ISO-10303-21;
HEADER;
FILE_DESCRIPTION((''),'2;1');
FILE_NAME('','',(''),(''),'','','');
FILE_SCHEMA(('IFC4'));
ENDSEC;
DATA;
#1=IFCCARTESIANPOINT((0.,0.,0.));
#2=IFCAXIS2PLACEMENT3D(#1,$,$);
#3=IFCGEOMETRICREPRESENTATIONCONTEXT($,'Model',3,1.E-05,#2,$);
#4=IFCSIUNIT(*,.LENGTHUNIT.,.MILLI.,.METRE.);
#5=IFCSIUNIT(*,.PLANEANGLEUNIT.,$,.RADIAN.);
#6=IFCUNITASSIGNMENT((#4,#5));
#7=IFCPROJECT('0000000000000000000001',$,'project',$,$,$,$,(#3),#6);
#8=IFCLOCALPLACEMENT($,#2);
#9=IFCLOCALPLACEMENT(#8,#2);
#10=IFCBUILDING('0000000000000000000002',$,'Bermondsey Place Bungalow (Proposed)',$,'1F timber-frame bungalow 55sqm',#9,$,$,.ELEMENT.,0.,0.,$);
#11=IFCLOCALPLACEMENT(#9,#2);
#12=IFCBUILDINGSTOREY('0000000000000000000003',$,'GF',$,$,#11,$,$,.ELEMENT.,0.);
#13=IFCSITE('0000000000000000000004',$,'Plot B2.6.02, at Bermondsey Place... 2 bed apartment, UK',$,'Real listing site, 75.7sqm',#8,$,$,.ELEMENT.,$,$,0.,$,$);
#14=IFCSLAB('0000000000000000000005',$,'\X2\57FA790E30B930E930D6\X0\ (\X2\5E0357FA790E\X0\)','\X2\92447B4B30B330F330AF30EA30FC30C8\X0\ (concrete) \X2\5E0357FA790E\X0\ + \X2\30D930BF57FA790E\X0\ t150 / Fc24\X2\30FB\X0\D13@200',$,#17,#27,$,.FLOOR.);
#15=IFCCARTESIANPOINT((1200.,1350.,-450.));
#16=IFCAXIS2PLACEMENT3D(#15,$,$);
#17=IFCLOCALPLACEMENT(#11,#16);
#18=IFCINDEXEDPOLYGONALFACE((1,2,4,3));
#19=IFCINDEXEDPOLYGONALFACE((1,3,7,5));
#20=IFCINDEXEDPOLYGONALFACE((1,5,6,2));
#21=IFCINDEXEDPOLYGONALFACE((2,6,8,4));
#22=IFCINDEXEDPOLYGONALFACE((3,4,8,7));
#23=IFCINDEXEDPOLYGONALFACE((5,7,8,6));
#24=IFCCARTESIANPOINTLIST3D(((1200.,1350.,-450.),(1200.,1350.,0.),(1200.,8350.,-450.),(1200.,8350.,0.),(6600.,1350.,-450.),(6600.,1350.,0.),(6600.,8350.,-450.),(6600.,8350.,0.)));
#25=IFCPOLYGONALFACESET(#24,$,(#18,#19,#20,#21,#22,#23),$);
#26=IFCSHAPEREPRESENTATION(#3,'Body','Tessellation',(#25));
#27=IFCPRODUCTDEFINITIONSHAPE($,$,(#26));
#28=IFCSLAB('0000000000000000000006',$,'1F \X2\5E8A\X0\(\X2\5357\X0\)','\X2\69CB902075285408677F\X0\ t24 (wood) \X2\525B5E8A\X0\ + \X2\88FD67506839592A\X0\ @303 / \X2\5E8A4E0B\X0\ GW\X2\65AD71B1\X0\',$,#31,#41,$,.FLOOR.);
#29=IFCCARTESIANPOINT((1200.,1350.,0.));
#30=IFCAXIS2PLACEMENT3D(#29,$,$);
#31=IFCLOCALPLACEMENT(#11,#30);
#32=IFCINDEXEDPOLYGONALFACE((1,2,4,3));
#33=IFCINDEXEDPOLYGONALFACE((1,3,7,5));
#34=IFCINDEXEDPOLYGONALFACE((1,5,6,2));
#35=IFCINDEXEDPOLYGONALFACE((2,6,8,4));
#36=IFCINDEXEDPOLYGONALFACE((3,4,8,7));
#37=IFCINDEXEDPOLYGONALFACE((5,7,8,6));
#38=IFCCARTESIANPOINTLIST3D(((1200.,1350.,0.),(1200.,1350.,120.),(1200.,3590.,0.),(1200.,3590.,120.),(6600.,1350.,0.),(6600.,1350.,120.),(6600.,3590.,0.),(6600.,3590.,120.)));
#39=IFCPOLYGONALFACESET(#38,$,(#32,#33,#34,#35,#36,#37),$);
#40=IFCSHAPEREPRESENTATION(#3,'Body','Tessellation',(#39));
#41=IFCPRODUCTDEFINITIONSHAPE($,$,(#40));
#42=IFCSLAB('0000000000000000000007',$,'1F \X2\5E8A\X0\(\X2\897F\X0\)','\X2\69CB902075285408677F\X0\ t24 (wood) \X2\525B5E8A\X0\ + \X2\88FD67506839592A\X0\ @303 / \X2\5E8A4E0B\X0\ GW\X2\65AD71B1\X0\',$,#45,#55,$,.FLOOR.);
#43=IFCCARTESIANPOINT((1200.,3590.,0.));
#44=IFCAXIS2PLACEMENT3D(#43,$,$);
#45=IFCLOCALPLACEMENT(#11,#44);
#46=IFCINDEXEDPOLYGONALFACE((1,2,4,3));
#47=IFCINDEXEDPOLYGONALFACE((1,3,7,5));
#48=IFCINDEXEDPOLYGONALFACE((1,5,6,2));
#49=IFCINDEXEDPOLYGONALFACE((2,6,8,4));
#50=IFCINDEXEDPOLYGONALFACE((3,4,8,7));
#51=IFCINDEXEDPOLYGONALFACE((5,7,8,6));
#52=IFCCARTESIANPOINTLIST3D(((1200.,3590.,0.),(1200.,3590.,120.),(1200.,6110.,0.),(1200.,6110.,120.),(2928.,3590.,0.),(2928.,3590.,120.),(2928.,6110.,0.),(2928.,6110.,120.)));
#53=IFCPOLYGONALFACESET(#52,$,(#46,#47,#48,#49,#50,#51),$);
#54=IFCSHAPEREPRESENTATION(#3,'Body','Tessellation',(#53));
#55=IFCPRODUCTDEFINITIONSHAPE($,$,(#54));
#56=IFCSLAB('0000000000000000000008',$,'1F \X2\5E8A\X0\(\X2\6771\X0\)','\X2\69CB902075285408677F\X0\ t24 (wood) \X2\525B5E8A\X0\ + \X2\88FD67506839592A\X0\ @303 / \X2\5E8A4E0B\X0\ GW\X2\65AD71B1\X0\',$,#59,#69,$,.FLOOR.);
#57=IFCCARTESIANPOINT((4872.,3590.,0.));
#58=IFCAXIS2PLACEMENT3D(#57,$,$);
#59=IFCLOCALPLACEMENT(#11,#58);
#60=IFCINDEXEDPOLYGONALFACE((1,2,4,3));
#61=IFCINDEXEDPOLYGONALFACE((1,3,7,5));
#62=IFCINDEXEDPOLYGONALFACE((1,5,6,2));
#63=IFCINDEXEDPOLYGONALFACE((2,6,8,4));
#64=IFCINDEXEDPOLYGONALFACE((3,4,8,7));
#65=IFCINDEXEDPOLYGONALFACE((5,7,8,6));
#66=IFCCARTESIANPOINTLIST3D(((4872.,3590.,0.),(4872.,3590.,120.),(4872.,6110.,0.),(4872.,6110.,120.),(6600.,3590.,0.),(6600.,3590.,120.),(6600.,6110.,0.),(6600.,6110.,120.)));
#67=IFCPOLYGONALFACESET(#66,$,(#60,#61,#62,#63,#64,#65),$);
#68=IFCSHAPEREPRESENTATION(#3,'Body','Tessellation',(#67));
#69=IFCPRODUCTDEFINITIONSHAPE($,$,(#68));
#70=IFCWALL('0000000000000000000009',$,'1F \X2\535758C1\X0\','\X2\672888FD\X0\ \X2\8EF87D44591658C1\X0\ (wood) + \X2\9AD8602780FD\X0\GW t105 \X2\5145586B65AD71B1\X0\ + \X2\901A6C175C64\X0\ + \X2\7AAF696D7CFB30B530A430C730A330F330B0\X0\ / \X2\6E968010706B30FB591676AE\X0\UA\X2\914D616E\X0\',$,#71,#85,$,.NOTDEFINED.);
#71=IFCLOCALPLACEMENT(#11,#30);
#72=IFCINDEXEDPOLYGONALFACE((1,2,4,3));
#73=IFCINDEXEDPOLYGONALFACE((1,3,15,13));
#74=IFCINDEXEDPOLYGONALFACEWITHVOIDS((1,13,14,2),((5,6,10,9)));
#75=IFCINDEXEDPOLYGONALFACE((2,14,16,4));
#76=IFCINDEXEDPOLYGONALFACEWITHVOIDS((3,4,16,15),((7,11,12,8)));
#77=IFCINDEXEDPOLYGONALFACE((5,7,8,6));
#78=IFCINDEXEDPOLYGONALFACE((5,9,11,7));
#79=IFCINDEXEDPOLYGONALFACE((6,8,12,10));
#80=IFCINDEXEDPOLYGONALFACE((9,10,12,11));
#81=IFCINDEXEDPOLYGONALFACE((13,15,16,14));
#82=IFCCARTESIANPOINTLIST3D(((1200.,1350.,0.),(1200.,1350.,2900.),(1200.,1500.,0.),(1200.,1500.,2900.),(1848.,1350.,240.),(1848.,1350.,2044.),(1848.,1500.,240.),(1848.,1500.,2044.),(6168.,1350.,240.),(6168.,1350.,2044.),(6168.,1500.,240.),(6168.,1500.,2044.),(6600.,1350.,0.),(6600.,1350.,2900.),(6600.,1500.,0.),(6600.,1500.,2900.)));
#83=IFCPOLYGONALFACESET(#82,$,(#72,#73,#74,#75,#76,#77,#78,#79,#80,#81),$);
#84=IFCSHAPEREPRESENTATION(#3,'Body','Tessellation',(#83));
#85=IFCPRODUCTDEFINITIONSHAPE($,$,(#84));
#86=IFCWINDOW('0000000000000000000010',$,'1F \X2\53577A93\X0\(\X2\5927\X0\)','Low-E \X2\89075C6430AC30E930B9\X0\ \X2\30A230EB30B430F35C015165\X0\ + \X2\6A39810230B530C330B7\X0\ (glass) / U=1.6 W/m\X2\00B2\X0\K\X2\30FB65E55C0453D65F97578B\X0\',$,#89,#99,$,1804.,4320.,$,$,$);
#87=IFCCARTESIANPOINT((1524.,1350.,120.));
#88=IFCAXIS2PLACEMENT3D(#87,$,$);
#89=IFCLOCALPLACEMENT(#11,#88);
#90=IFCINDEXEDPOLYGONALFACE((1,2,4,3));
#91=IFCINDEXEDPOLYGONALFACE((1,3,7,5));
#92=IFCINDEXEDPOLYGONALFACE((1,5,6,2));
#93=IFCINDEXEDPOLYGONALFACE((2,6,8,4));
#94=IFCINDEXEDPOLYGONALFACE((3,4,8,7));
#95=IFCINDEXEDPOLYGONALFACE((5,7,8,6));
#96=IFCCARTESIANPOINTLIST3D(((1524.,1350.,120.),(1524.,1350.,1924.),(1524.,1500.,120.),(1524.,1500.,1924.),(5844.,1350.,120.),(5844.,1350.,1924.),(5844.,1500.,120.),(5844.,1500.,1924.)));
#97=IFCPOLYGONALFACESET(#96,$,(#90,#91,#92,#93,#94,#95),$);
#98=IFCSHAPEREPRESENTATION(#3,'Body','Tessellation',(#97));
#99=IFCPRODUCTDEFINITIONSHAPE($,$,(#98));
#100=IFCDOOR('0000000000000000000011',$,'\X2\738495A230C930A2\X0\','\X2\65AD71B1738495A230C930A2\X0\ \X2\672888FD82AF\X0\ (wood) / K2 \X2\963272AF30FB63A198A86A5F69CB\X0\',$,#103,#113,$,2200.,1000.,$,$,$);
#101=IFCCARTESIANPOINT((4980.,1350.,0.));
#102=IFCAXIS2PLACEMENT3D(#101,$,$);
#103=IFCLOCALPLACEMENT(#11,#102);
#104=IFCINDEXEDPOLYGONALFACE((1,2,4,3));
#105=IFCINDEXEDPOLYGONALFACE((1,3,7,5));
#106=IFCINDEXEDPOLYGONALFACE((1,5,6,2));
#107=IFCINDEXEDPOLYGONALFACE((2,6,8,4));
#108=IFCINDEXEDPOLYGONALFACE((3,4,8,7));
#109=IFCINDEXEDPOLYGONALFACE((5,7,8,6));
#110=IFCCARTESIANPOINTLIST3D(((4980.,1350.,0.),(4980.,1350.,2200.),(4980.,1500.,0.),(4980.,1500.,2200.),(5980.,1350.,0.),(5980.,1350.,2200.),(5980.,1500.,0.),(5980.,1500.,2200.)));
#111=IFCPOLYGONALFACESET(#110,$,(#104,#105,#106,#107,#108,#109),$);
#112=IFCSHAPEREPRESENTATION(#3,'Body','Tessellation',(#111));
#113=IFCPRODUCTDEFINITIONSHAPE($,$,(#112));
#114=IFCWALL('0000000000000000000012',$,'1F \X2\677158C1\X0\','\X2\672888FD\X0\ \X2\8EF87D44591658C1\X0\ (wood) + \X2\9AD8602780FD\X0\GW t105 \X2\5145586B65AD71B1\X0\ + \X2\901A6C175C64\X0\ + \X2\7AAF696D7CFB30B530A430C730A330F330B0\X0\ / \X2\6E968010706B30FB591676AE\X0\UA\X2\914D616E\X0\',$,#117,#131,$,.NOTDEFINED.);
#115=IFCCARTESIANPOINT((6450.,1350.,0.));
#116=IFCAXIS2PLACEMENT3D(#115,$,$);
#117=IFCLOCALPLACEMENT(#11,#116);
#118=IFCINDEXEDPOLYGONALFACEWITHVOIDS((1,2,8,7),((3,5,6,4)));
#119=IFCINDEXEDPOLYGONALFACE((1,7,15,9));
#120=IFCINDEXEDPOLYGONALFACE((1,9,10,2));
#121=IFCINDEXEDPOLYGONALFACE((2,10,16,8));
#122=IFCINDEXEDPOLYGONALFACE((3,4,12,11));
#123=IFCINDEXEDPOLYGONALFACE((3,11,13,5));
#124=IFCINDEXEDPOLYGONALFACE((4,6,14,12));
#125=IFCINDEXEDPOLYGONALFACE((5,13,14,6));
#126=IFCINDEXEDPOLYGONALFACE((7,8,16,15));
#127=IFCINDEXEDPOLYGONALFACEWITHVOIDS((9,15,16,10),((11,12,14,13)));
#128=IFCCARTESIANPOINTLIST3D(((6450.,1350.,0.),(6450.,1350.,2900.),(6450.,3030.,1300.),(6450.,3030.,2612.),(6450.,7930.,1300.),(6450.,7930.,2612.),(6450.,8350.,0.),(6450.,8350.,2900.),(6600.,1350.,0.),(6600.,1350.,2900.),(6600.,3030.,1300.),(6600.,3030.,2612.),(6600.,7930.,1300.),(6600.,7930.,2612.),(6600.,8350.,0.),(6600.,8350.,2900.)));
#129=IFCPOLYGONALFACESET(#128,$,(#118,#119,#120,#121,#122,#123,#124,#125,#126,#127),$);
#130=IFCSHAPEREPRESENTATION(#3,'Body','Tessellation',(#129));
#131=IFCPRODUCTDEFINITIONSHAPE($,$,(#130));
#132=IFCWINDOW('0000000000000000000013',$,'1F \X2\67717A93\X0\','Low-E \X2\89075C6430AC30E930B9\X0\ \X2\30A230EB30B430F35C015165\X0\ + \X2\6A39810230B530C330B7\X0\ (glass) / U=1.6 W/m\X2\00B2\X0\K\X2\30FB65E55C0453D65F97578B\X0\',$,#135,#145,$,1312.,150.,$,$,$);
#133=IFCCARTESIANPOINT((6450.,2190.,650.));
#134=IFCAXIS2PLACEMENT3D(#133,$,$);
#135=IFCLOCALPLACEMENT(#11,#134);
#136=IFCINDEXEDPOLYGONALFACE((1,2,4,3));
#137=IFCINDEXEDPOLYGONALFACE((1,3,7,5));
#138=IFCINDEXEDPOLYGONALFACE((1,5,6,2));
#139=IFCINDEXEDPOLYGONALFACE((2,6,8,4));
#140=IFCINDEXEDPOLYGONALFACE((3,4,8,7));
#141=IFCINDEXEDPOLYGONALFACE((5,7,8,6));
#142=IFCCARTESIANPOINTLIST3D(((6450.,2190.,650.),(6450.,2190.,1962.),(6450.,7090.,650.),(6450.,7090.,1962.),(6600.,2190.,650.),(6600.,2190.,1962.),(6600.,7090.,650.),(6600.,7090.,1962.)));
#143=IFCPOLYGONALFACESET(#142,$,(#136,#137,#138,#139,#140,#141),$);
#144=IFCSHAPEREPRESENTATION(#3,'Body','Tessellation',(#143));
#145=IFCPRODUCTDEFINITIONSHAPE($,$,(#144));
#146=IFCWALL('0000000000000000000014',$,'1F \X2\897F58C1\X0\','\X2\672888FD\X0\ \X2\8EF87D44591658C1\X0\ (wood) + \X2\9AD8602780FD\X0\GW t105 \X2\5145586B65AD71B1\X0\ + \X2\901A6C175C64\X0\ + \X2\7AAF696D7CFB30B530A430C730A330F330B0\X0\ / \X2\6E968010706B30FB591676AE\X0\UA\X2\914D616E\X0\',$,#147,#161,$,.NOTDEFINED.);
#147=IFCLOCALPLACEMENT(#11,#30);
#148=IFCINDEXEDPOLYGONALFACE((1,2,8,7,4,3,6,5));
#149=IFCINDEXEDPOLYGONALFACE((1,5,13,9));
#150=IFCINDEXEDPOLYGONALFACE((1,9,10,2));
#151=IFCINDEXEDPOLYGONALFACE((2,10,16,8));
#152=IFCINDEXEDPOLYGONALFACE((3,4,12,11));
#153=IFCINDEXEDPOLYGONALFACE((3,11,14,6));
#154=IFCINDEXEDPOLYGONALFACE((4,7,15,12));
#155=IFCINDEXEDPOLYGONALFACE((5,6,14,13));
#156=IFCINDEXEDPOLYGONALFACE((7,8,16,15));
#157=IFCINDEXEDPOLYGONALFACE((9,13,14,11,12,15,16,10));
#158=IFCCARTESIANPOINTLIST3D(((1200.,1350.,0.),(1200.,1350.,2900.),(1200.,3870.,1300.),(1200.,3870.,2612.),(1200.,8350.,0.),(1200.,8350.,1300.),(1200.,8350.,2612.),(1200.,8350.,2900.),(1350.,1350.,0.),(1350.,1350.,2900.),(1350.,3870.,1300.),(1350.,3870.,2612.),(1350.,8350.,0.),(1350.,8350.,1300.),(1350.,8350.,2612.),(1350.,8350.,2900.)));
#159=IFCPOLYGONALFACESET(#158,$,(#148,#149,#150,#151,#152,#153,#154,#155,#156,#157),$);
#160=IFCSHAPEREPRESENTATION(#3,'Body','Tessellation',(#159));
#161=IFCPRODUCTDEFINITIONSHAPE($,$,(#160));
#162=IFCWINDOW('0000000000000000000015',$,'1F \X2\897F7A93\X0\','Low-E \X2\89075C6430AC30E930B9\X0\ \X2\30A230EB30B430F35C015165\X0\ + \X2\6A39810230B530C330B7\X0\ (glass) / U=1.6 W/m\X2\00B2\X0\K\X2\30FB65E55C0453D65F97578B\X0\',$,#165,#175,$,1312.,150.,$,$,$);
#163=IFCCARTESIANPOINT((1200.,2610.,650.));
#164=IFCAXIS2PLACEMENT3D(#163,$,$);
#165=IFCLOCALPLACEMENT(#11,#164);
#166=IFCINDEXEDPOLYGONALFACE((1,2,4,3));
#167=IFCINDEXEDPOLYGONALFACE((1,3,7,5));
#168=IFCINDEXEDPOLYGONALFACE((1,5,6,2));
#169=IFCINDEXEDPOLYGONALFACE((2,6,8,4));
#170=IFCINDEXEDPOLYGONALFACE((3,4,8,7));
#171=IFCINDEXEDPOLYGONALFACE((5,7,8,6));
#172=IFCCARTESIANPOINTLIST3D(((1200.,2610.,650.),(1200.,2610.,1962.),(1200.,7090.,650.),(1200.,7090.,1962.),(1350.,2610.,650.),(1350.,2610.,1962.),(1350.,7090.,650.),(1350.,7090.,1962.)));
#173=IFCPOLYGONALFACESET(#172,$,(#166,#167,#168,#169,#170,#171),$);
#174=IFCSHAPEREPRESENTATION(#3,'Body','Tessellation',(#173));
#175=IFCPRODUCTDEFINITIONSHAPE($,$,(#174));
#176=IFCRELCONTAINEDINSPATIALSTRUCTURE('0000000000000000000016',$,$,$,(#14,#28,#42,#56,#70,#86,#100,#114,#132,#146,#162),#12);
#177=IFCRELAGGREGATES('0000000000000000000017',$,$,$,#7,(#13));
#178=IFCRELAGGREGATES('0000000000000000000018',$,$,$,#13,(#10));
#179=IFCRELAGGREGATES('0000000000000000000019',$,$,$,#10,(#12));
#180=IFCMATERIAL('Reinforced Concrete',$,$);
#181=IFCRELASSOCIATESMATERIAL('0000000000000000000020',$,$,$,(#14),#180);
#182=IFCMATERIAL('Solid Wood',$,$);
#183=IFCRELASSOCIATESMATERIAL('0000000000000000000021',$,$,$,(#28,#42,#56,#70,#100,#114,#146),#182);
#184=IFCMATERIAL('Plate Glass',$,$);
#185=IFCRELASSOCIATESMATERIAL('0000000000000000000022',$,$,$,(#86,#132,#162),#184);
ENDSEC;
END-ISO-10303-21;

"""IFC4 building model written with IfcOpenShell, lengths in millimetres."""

from ifc_helpers import new_model, si_unit, frame, frame_2d, origin, place, context, project, spatial, rectangle, extrude, material, element, fill, save


model = new_model("IFC4")

# Units and contexts
model_context = context("Model", 3, precision=1e-05, world=origin())
ifc_project = project(units=[si_unit("LENGTHUNIT", "METRE", prefix="MILLI"), si_unit("PLANEANGLEUNIT", "RADIAN")], contexts=[model_context])

# Site, building, storey
site_placement = place(None, origin())
site = spatial("IfcSite", under=ifc_project, at=site_placement, Name="Plot B2.6.02, at Bermondsey Place... 2 bed apartment, UK", ObjectType="Real listing site, 75.7sqm", CompositionType="ELEMENT", RefElevation=0.0)
building_placement = place(site_placement, origin())
building = spatial("IfcBuilding", under=site, at=building_placement, Name="Bermondsey Place Bungalow (Proposed)", ObjectType="1F timber-frame bungalow 55sqm", CompositionType="ELEMENT", ElevationOfRefHeight=0.0, ElevationOfTerrain=0.0)
storey_placement = place(building_placement, origin())
storey = spatial("IfcBuildingStorey", under=building, at=storey_placement, Name="GF", CompositionType="ELEMENT", Elevation=0.0)

# Slabs
ifc_material_1 = material(Name="Reinforced Concrete")
slab_1_placement = place(storey_placement, frame((1200.0, 1350.0, -450.0)))
element("IfcSlab", 1, at=slab_1_placement, inside=storey, material=ifc_material_1, Name="基礎スラブ (布基礎)", Description="鉄筋コンクリート (concrete) 布基礎 + ベタ基礎 t150 / Fc24・D13@200", PredefinedType="FLOOR", context=model_context, shape_type="SweptSolid", body=[
    extrude(rectangle(XDim=5400.0, YDim=7000.0, at=frame_2d((2700.0, 3500.0))), frame((1200.0, 1350.0, -450.0)), (0.0, 0.0, 1.0), 450.0),
])
ifc_material_2 = material(Name="Solid Wood")
slab_2_placement = place(storey_placement, frame((1200.0, 1350.0, 0.0)))
element("IfcSlab", 2, at=slab_2_placement, inside=storey, material=ifc_material_2, Name="1F 床(南)", Description="構造用合板 t24 (wood) 剛床 + 製材根太 @303 / 床下 GW断熱", PredefinedType="FLOOR", context=model_context, shape_type="SweptSolid", body=[
    extrude(rectangle(XDim=5400.0, YDim=2240.0, at=frame_2d((2700.0, 1120.0))), frame((1200.0, 1350.0, 0.0)), (0.0, 0.0, 1.0), 120.0),
])
slab_3_placement = place(storey_placement, frame((1200.0, 3590.0, 0.0)))
element("IfcSlab", 3, at=slab_3_placement, inside=storey, material=ifc_material_2, Name="1F 床(西)", Description="構造用合板 t24 (wood) 剛床 + 製材根太 @303 / 床下 GW断熱", PredefinedType="FLOOR", context=model_context, shape_type="SweptSolid", body=[
    extrude(rectangle(XDim=1728.0, YDim=2520.0, at=frame_2d((864.0, 1260.0))), frame((1200.0, 3590.0, 0.0)), (0.0, 0.0, 1.0), 120.0),
])
slab_4_placement = place(storey_placement, frame((4872.0, 3590.0, 0.0)))
element("IfcSlab", 4, at=slab_4_placement, inside=storey, material=ifc_material_2, Name="1F 床(東)", Description="構造用合板 t24 (wood) 剛床 + 製材根太 @303 / 床下 GW断熱", PredefinedType="FLOOR", context=model_context, shape_type="SweptSolid", body=[
    extrude(rectangle(XDim=1728.0, YDim=2520.0, at=frame_2d((864.0, 1260.0))), frame((4872.0, 3590.0, 0.0)), (0.0, 0.0, 1.0), 120.0),
])

# Wall, openings, window, door
wall_1_placement = place(storey_placement, frame((1200.0, 1350.0, 0.0)))
wall_1 = element("IfcWall", 5, at=wall_1_placement, inside=storey, material=ifc_material_2, Name="1F 南壁", Description="木製 軸組外壁 (wood) + 高性能GW t105 充填断熱 + 通気層 + 窯業系サイディング / 準耐火・外皮UA配慮", PredefinedType="NOTDEFINED", context=model_context, shape_type="SweptSolid", body=[
    extrude(rectangle(XDim=5400.0, YDim=150.0, at=frame_2d((2700.0, 75.0))), frame((1200.0, 1350.0, 0.0)), (0.0, 0.0, 1.0), 2900.0),
])
opening_1_placement = place(storey_placement, frame((1524.0, 1350.0, 120.0)))
opening_1 = element("IfcOpeningElement", 6, at=opening_1_placement, cuts=wall_1, PredefinedType="NOTDEFINED", context=model_context, shape_type="SweptSolid", body=[
    extrude(rectangle(XDim=4320.0, YDim=150.0, at=frame_2d((2160.0, 75.0))), frame((1524.0, 1350.0, 120.0)), (0.0, 0.0, 1.0), 1804.0),
])
opening_2_placement = place(storey_placement, frame((4980.0, 1350.0, 0.0)))
opening_2 = element("IfcOpeningElement", 7, at=opening_2_placement, cuts=wall_1, PredefinedType="NOTDEFINED", context=model_context, shape_type="SweptSolid", body=[
    extrude(rectangle(XDim=1000.0, YDim=150.0, at=frame_2d((500.0, 75.0))), frame((4980.0, 1350.0, 0.0)), (0.0, 0.0, 1.0), 2200.0),
])
ifc_material_3 = material(Name="Plate Glass")
window_1_placement = place(storey_placement, frame((1524.0, 1350.0, 120.0)))
window_1 = element("IfcWindow", 8, at=window_1_placement, inside=storey, material=ifc_material_3, Name="1F 南窓(大)", Description="Low-E 複層ガラス アルゴン封入 + 樹脂サッシ (glass) / U=1.6 W/m²K・日射取得型", OverallHeight=1804.0, OverallWidth=4320.0, context=model_context, shape_type="SweptSolid", body=[
    extrude(rectangle(XDim=4320.0, YDim=150.0, at=frame_2d((2160.0, 75.0))), frame((1524.0, 1350.0, 120.0)), (0.0, 0.0, 1.0), 1804.0),
])
fill(opening_1, window_1)
door_placement = place(storey_placement, frame((4980.0, 1350.0, 0.0)))
door = element("IfcDoor", 9, at=door_placement, inside=storey, material=ifc_material_2, Name="玄関ドア", Description="断熱玄関ドア 木製芯 (wood) / K2 防犯・採風機構", OverallHeight=2200.0, OverallWidth=1000.0, context=model_context, shape_type="SweptSolid", body=[
    extrude(rectangle(XDim=1000.0, YDim=150.0, at=frame_2d((500.0, 75.0))), frame((4980.0, 1350.0, 0.0)), (0.0, 0.0, 1.0), 2200.0),
])
fill(opening_2, door)

# Walls, openings, windows
wall_2_placement = place(storey_placement, frame((6450.0, 1350.0, 0.0)))
wall_2 = element("IfcWall", 10, at=wall_2_placement, inside=storey, material=ifc_material_2, Name="1F 東壁", Description="木製 軸組外壁 (wood) + 高性能GW t105 充填断熱 + 通気層 + 窯業系サイディング / 準耐火・外皮UA配慮", PredefinedType="NOTDEFINED", context=model_context, shape_type="SweptSolid", body=[
    extrude(rectangle(XDim=150.0, YDim=7000.0, at=frame_2d((75.0, 3500.0))), frame((6450.0, 1350.0, 0.0)), (0.0, 0.0, 1.0), 2900.0),
])
opening_3_placement = place(storey_placement, frame((6450.0, 2190.0, 650.0)))
opening_3 = element("IfcOpeningElement", 11, at=opening_3_placement, cuts=wall_2, PredefinedType="NOTDEFINED", context=model_context, shape_type="SweptSolid", body=[
    extrude(rectangle(XDim=150.0, YDim=4900.0, at=frame_2d((75.0, 2450.0))), frame((6450.0, 2190.0, 650.0)), (0.0, 0.0, 1.0), 1312.0),
])
window_2_placement = place(storey_placement, frame((6450.0, 2190.0, 650.0)))
window_2 = element("IfcWindow", 12, at=window_2_placement, inside=storey, material=ifc_material_3, Name="1F 東窓", Description="Low-E 複層ガラス アルゴン封入 + 樹脂サッシ (glass) / U=1.6 W/m²K・日射取得型", OverallHeight=1312.0, OverallWidth=150.0, context=model_context, shape_type="SweptSolid", body=[
    extrude(rectangle(XDim=150.0, YDim=4900.0, at=frame_2d((75.0, 2450.0))), frame((6450.0, 2190.0, 650.0)), (0.0, 0.0, 1.0), 1312.0),
])
fill(opening_3, window_2)
wall_3_placement = place(storey_placement, frame((1200.0, 1350.0, 0.0)))
wall_3 = element("IfcWall", 13, at=wall_3_placement, inside=storey, material=ifc_material_2, Name="1F 西壁", Description="木製 軸組外壁 (wood) + 高性能GW t105 充填断熱 + 通気層 + 窯業系サイディング / 準耐火・外皮UA配慮", PredefinedType="NOTDEFINED", context=model_context, shape_type="SweptSolid", body=[
    extrude(rectangle(XDim=150.0, YDim=7000.0, at=frame_2d((75.0, 3500.0))), frame((1200.0, 1350.0, 0.0)), (0.0, 0.0, 1.0), 2900.0),
])
opening_4_placement = place(storey_placement, frame((1200.0, 2610.0, 650.0)))
opening_4 = element("IfcOpeningElement", 14, at=opening_4_placement, cuts=wall_3, PredefinedType="NOTDEFINED", context=model_context, shape_type="SweptSolid", body=[
    extrude(rectangle(XDim=150.0, YDim=4480.0, at=frame_2d((75.0, 2240.0))), frame((1200.0, 2610.0, 650.0)), (0.0, 0.0, 1.0), 1312.0),
])
window_3_placement = place(storey_placement, frame((1200.0, 2610.0, 650.0)))
window_3 = element("IfcWindow", 15, at=window_3_placement, inside=storey, material=ifc_material_3, Name="1F 西窓", Description="Low-E 複層ガラス アルゴン封入 + 樹脂サッシ (glass) / U=1.6 W/m²K・日射取得型", OverallHeight=1312.0, OverallWidth=150.0, context=model_context, shape_type="SweptSolid", body=[
    extrude(rectangle(XDim=150.0, YDim=4480.0, at=frame_2d((75.0, 2240.0))), frame((1200.0, 2610.0, 650.0)), (0.0, 0.0, 1.0), 1312.0),
])
fill(opening_4, window_3)

save(model, "model.ifc")
